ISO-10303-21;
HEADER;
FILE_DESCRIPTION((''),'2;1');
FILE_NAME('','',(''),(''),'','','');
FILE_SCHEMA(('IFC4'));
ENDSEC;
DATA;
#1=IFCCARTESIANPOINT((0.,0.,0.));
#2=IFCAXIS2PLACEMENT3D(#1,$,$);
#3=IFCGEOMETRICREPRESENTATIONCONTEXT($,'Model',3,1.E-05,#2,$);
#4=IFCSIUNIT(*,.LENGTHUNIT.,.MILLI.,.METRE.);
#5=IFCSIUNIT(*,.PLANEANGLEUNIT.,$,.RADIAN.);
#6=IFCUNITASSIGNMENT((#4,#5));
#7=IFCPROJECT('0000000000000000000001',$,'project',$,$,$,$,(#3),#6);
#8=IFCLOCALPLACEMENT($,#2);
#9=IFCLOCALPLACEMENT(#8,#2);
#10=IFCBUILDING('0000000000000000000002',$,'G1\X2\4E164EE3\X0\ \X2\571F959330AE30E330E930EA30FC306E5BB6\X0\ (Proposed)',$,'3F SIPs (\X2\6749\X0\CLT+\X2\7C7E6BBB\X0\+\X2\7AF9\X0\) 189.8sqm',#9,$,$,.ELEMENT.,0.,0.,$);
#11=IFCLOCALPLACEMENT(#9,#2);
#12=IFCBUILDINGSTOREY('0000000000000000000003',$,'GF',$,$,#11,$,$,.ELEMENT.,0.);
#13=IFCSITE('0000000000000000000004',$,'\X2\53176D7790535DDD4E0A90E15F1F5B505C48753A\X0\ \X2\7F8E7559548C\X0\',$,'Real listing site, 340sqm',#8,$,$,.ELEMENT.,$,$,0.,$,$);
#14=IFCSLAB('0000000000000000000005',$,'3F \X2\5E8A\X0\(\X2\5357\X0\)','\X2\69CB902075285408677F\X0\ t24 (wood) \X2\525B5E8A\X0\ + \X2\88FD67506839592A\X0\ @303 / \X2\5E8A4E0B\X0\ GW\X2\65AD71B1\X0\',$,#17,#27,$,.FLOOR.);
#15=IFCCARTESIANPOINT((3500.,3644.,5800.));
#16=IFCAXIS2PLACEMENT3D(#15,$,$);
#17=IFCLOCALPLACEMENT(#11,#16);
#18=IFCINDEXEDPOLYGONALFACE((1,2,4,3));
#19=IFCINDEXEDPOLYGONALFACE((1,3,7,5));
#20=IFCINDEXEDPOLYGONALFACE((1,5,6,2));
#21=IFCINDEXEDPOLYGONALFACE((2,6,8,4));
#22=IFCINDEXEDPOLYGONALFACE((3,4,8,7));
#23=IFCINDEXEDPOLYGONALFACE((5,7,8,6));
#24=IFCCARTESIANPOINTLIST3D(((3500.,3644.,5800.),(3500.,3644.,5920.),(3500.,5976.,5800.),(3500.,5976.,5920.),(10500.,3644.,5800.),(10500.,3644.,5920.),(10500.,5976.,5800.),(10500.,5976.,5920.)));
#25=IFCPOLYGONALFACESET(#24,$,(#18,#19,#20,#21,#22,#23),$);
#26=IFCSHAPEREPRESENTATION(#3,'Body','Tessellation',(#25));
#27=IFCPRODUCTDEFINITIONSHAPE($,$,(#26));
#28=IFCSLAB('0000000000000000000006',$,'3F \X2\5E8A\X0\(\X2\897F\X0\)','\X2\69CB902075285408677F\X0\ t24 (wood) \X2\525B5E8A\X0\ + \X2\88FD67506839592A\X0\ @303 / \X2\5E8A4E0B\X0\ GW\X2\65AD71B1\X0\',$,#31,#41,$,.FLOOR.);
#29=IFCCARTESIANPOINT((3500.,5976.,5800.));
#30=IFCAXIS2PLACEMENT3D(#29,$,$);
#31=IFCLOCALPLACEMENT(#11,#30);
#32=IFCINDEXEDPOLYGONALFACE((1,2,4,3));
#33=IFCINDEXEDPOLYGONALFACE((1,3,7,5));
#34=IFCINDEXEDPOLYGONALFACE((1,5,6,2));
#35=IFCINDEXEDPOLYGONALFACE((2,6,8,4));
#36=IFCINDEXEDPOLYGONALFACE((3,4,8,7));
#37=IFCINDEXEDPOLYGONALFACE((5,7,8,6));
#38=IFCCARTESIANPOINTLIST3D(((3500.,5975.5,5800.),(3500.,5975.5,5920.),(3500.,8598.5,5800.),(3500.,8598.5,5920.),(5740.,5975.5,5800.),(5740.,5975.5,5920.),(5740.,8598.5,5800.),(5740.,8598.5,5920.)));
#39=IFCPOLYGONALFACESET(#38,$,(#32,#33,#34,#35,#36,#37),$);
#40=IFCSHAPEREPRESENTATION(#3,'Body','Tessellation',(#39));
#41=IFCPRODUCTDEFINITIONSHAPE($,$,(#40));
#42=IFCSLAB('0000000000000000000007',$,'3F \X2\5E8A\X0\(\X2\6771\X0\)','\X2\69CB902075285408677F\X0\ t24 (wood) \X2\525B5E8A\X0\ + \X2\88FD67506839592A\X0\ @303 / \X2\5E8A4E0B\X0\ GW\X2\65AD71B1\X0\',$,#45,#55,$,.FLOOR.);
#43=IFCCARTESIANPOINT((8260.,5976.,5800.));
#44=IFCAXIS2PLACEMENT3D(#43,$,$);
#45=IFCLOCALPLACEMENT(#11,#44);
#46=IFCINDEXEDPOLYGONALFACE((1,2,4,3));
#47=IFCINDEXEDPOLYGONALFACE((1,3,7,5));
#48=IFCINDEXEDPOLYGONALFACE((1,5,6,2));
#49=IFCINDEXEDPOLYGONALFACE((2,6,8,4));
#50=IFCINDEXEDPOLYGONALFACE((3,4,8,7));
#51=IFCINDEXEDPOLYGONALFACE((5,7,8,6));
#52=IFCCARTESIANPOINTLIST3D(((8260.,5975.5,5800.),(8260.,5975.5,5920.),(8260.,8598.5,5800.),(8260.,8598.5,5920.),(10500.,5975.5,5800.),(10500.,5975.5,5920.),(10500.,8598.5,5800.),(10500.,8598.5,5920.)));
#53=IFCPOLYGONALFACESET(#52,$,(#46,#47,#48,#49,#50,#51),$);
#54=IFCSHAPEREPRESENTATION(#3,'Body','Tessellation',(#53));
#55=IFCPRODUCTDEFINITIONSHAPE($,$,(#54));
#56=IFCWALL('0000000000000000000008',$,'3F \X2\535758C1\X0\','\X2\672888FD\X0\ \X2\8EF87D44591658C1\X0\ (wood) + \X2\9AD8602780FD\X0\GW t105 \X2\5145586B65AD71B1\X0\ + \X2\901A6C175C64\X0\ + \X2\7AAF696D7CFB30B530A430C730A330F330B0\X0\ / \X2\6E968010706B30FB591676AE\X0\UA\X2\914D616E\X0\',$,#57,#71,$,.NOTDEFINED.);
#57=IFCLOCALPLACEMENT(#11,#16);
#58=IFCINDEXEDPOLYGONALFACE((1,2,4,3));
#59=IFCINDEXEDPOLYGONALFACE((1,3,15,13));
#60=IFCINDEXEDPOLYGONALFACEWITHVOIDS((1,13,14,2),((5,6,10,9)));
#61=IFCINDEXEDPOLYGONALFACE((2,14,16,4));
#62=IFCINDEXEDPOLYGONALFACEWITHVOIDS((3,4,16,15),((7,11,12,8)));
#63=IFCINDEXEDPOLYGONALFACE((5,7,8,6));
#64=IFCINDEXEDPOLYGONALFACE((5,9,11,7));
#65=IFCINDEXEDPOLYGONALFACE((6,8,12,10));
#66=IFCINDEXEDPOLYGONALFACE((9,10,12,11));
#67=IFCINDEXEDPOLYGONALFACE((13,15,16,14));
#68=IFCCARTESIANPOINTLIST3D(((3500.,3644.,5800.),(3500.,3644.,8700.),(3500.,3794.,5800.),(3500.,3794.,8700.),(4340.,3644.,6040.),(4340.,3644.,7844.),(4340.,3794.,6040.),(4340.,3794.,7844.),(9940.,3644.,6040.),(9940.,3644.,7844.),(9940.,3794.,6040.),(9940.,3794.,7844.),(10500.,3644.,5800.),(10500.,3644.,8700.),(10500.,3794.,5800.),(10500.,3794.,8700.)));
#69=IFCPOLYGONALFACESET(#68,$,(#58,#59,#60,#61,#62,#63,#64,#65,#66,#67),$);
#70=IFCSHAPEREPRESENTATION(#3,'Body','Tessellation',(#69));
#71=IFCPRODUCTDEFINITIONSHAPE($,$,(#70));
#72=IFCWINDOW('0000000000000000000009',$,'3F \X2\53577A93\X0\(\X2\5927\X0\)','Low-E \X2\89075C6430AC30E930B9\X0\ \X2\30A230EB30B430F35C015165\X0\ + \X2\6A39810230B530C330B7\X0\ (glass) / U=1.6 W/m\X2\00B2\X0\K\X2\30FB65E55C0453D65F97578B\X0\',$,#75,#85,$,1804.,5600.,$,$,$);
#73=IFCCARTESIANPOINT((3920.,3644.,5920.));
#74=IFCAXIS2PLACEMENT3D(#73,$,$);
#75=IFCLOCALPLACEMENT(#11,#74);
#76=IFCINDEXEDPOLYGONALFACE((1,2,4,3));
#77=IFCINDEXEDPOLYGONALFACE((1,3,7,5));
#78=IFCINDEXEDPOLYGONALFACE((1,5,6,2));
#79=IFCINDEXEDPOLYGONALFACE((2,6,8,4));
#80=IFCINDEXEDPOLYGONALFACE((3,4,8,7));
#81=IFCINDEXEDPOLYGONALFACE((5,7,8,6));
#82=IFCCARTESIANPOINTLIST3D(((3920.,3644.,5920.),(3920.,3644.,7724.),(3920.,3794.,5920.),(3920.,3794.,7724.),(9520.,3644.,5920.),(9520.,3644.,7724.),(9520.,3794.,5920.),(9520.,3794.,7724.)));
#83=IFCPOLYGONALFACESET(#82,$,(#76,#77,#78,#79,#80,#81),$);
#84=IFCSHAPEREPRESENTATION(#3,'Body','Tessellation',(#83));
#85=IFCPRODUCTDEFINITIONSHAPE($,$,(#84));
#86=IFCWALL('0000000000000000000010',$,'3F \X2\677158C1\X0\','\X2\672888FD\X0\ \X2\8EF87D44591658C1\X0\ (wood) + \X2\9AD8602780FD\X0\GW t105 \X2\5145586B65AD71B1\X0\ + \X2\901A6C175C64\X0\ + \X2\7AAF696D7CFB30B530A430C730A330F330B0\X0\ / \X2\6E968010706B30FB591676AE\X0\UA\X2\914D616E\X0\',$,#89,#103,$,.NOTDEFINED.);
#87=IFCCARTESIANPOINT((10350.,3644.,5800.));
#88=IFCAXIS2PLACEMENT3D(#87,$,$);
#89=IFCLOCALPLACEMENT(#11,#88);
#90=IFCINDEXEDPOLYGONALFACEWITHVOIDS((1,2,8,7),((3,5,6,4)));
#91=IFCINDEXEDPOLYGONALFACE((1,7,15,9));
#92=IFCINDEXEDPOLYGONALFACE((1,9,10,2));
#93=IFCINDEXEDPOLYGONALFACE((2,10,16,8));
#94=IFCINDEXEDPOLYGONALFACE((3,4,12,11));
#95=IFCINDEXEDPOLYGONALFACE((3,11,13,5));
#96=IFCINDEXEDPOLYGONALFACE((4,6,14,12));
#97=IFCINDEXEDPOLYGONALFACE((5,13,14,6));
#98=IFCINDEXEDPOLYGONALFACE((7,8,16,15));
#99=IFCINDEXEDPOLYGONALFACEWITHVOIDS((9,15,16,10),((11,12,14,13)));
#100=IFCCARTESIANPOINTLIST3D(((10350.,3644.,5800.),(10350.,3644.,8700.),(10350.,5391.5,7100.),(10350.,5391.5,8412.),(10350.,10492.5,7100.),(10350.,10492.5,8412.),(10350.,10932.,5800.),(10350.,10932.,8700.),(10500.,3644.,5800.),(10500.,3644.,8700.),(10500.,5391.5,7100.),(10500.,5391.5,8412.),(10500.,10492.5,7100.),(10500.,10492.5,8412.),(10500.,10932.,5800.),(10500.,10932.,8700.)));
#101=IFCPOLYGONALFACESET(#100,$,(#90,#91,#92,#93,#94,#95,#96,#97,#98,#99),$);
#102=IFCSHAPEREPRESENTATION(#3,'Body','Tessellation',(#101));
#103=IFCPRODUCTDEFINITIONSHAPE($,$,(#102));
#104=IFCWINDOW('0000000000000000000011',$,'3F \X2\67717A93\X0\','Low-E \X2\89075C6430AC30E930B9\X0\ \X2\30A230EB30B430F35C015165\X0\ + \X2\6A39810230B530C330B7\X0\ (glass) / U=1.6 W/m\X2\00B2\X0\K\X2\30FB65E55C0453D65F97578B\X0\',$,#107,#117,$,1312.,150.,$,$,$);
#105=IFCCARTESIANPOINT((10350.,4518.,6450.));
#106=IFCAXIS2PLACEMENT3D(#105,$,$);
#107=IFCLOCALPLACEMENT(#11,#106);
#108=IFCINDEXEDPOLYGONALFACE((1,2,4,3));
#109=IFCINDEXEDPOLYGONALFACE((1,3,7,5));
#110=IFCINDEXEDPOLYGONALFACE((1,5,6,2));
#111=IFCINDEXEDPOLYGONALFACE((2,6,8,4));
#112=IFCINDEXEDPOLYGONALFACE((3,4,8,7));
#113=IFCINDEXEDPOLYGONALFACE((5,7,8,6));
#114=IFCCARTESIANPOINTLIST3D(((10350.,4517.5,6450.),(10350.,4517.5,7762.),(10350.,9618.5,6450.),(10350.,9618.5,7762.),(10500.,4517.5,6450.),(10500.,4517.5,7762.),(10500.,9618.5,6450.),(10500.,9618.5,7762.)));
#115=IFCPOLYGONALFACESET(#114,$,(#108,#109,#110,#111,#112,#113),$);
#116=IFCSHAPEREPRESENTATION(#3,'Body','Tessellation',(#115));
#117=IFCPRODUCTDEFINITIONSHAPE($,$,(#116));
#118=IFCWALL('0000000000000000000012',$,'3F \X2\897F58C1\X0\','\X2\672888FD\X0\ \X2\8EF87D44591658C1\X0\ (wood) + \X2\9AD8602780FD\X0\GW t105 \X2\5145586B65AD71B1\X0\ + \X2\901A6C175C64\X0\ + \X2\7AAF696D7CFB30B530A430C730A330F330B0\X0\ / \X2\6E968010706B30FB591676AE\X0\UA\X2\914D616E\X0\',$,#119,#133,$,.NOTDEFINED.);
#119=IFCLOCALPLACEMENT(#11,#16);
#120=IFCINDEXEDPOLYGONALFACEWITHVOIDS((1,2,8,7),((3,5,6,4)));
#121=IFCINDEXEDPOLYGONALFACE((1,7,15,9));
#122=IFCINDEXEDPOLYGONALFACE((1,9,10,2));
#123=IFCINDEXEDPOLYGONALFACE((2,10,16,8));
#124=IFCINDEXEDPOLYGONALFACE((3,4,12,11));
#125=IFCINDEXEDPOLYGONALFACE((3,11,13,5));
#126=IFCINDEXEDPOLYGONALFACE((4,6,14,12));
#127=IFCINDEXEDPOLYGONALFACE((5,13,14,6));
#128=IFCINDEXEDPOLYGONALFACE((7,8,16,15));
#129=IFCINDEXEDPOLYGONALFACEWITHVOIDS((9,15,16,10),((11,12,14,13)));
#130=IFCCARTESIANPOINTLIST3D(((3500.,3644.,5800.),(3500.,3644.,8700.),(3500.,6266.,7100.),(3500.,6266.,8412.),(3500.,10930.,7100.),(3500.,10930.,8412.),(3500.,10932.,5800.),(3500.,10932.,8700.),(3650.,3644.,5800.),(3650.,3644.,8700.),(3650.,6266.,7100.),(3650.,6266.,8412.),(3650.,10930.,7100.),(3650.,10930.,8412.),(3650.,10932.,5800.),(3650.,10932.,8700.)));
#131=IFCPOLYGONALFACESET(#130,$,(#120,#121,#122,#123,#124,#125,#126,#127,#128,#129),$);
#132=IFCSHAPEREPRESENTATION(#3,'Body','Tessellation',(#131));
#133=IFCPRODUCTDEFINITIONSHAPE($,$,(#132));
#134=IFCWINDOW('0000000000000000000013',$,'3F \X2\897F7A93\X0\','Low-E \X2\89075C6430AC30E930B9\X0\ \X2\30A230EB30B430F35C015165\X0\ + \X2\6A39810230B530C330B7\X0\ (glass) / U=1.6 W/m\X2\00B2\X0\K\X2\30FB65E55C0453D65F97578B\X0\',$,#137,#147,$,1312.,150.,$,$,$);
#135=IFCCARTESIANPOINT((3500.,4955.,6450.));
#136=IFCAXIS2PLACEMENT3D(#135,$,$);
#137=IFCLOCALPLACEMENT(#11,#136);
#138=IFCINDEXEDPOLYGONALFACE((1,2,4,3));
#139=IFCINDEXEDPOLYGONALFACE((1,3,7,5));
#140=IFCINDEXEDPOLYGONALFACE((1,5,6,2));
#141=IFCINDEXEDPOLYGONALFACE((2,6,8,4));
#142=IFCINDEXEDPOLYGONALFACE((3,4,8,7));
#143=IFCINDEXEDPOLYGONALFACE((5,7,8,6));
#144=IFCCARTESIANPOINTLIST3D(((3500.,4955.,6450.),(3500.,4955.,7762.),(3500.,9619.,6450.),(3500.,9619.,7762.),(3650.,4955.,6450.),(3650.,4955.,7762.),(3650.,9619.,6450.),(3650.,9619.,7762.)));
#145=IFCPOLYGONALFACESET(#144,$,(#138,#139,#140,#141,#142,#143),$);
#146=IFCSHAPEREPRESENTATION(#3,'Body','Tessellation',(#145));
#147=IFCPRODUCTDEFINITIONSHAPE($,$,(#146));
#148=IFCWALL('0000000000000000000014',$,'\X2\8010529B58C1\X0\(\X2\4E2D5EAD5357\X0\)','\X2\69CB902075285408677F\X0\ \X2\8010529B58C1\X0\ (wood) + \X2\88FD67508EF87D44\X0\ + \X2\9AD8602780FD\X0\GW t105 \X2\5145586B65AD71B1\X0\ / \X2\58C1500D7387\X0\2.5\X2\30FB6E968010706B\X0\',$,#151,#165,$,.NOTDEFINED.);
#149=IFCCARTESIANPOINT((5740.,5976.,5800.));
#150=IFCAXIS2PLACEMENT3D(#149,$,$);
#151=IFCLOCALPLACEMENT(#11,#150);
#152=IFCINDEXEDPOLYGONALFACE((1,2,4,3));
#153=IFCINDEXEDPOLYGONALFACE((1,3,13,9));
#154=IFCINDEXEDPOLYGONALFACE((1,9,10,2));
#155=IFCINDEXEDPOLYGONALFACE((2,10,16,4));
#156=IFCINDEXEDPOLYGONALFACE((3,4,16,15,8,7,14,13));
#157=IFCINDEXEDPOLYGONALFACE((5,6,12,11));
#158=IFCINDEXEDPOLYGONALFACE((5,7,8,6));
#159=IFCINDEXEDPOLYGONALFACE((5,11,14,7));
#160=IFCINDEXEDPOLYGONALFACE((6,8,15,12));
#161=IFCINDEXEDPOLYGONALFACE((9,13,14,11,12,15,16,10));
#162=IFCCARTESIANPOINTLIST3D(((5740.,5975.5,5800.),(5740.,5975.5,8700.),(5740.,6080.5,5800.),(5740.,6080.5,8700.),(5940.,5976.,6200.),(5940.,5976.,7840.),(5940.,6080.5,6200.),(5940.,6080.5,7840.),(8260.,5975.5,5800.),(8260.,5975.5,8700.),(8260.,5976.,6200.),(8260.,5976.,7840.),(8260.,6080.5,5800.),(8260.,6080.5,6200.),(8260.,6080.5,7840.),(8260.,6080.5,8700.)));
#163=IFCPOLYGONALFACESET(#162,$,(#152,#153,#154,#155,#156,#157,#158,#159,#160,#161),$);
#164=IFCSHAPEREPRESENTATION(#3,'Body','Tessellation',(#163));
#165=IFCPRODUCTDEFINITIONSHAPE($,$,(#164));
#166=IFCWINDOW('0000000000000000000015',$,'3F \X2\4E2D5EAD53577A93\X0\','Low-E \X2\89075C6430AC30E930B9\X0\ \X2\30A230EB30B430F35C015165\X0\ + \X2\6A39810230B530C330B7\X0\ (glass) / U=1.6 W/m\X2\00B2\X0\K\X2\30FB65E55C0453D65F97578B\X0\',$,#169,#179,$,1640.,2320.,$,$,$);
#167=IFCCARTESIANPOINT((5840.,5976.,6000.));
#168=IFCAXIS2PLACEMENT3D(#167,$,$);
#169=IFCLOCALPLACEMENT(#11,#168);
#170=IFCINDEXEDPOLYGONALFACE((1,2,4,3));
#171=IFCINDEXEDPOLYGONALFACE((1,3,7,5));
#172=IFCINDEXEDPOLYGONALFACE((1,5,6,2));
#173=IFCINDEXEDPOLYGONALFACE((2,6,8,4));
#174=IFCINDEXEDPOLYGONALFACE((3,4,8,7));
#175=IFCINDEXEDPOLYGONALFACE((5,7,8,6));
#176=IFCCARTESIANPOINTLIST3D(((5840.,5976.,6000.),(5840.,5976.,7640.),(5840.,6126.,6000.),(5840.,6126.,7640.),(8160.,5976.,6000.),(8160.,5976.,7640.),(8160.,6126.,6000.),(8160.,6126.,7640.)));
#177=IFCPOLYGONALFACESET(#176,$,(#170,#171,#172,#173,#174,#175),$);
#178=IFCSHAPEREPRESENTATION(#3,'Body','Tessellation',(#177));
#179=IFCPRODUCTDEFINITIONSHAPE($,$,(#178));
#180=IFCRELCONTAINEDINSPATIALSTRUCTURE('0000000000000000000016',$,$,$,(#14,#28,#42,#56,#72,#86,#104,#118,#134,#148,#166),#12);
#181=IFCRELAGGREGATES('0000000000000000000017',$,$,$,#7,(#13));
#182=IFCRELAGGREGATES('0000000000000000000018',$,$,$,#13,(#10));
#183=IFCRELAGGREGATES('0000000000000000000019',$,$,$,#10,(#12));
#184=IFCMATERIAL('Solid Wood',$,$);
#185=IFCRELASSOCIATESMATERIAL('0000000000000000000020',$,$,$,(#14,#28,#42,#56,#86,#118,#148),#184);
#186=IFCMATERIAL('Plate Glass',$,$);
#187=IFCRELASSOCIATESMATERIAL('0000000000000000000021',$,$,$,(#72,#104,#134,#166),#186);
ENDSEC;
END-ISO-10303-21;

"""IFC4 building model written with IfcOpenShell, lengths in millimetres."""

from ifc_helpers import new_model, si_unit, frame, frame_2d, origin, place, context, project, spatial, rectangle, extrude, material, element, fill, save


model = new_model("IFC4")

# Units and contexts
model_context = context("Model", 3, precision=1e-05, world=origin())
ifc_project = project(units=[si_unit("LENGTHUNIT", "METRE", prefix="MILLI"), si_unit("PLANEANGLEUNIT", "RADIAN")], contexts=[model_context])

# Site, building, storey
site_placement = place(None, origin())
site = spatial("IfcSite", under=ifc_project, at=site_placement, Name="北海道川上郡弟子屈町 美留和", ObjectType="Real listing site, 340sqm", CompositionType="ELEMENT", RefElevation=0.0)
building_placement = place(site_placement, origin())
building = spatial("IfcBuilding", under=site, at=building_placement, Name="G1世代 土間ギャラリーの家 (Proposed)", ObjectType="3F SIPs (杉CLT+籾殻+竹) 189.8sqm", CompositionType="ELEMENT", ElevationOfRefHeight=0.0, ElevationOfTerrain=0.0)
storey_placement = place(building_placement, origin())
storey = spatial("IfcBuildingStorey", under=building, at=storey_placement, Name="GF", CompositionType="ELEMENT", Elevation=0.0)

# Slabs
ifc_material_1 = material(Name="Solid Wood")
slab_1_placement = place(storey_placement, frame((3500.0, 3644.0, 5800.0)))
element("IfcSlab", 1, at=slab_1_placement, inside=storey, material=ifc_material_1, Name="3F 床(南)", Description="構造用合板 t24 (wood) 剛床 + 製材根太 @303 / 床下 GW断熱", PredefinedType="FLOOR", context=model_context, shape_type="SweptSolid", body=[
    extrude(rectangle(XDim=7000.0, YDim=2332.0, at=frame_2d((3500.0, 1166.0))), frame((3500.0, 3644.0, 5800.0)), (0.0, 0.0, 1.0), 120.0),
])
slab_2_placement = place(storey_placement, frame((3500.0, 5976.0, 5800.0)))
element("IfcSlab", 2, at=slab_2_placement, inside=storey, material=ifc_material_1, Name="3F 床(西)", Description="構造用合板 t24 (wood) 剛床 + 製材根太 @303 / 床下 GW断熱", PredefinedType="FLOOR", context=model_context, shape_type="SweptSolid", body=[
    extrude(rectangle(XDim=2240.0, YDim=2623.0, at=frame_2d((1120.0, 1311.0))), frame((3500.0, 5976.0, 5800.0)), (0.0, 0.0, 1.0), 120.0),
])
slab_3_placement = place(storey_placement, frame((8260.0, 5976.0, 5800.0)))
element("IfcSlab", 3, at=slab_3_placement, inside=storey, material=ifc_material_1, Name="3F 床(東)", Description="構造用合板 t24 (wood) 剛床 + 製材根太 @303 / 床下 GW断熱", PredefinedType="FLOOR", context=model_context, shape_type="SweptSolid", body=[
    extrude(rectangle(XDim=2240.0, YDim=2623.0, at=frame_2d((1120.0, 1311.0))), frame((8260.0, 5976.0, 5800.0)), (0.0, 0.0, 1.0), 120.0),
])

# Walls, openings, windows
wall_1_placement = place(storey_placement, frame((3500.0, 3644.0, 5800.0)))
wall_1 = element("IfcWall", 4, at=wall_1_placement, inside=storey, material=ifc_material_1, Name="3F 南壁", Description="木製 軸組外壁 (wood) + 高性能GW t105 充填断熱 + 通気層 + 窯業系サイディング / 準耐火・外皮UA配慮", PredefinedType="NOTDEFINED", context=model_context, shape_type="SweptSolid", body=[
    extrude(rectangle(XDim=7000.0, YDim=150.0, at=frame_2d((3500.0, 75.0))), frame((3500.0, 3644.0, 5800.0)), (0.0, 0.0, 1.0), 2900.0),
])
opening_1_placement = place(storey_placement, frame((3920.0, 3644.0, 5920.0)))
opening_1 = element("IfcOpeningElement", 5, at=opening_1_placement, cuts=wall_1, PredefinedType="NOTDEFINED", context=model_context, shape_type="SweptSolid", body=[
    extrude(rectangle(XDim=5600.0, YDim=150.0, at=frame_2d((2800.0, 75.0))), frame((3920.0, 3644.0, 5920.0)), (0.0, 0.0, 1.0), 1804.0),
])
ifc_material_2 = material(Name="Plate Glass")
window_1_placement = place(storey_placement, frame((3920.0, 3644.0, 5920.0)))
window_1 = element("IfcWindow", 6, at=window_1_placement, inside=storey, material=ifc_material_2, Name="3F 南窓(大)", Description="Low-E 複層ガラス アルゴン封入 + 樹脂サッシ (glass) / U=1.6 W/m²K・日射取得型", OverallHeight=1804.0, OverallWidth=5600.0, context=model_context, shape_type="SweptSolid", body=[
    extrude(rectangle(XDim=5600.0, YDim=150.0, at=frame_2d((2800.0, 75.0))), frame((3920.0, 3644.0, 5920.0)), (0.0, 0.0, 1.0), 1804.0),
])
fill(opening_1, window_1)
wall_2_placement = place(storey_placement, frame((10350.0, 3644.0, 5800.0)))
wall_2 = element("IfcWall", 7, at=wall_2_placement, inside=storey, material=ifc_material_1, Name="3F 東壁", Description="木製 軸組外壁 (wood) + 高性能GW t105 充填断熱 + 通気層 + 窯業系サイディング / 準耐火・外皮UA配慮", PredefinedType="NOTDEFINED", context=model_context, shape_type="SweptSolid", body=[
    extrude(rectangle(XDim=150.0, YDim=7288.0, at=frame_2d((75.0, 3644.0))), frame((10350.0, 3644.0, 5800.0)), (0.0, 0.0, 1.0), 2900.0),
])
opening_2_placement = place(storey_placement, frame((10350.0, 4518.0, 6450.0)))
opening_2 = element("IfcOpeningElement", 8, at=opening_2_placement, cuts=wall_2, PredefinedType="NOTDEFINED", context=model_context, shape_type="SweptSolid", body=[
    extrude(rectangle(XDim=150.0, YDim=5101.0, at=frame_2d((75.0, 2550.0))), frame((10350.0, 4518.0, 6450.0)), (0.0, 0.0, 1.0), 1312.0),
])
window_2_placement = place(storey_placement, frame((10350.0, 4518.0, 6450.0)))
window_2 = element("IfcWindow", 9, at=window_2_placement, inside=storey, material=ifc_material_2, Name="3F 東窓", Description="Low-E 複層ガラス アルゴン封入 + 樹脂サッシ (glass) / U=1.6 W/m²K・日射取得型", OverallHeight=1312.0, OverallWidth=150.0, context=model_context, shape_type="SweptSolid", body=[
    extrude(rectangle(XDim=150.0, YDim=5101.0, at=frame_2d((75.0, 2550.0))), frame((10350.0, 4518.0, 6450.0)), (0.0, 0.0, 1.0), 1312.0),
])
fill(opening_2, window_2)
wall_3_placement = place(storey_placement, frame((3500.0, 3644.0, 5800.0)))
wall_3 = element("IfcWall", 10, at=wall_3_placement, inside=storey, material=ifc_material_1, Name="3F 西壁", Description="木製 軸組外壁 (wood) + 高性能GW t105 充填断熱 + 通気層 + 窯業系サイディング / 準耐火・外皮UA配慮", PredefinedType="NOTDEFINED", context=model_context, shape_type="SweptSolid", body=[
    extrude(rectangle(XDim=150.0, YDim=7288.0, at=frame_2d((75.0, 3644.0))), frame((3500.0, 3644.0, 5800.0)), (0.0, 0.0, 1.0), 2900.0),
])
opening_3_placement = place(storey_placement, frame((3500.0, 4955.0, 6450.0)))
opening_3 = element("IfcOpeningElement", 11, at=opening_3_placement, cuts=wall_3, PredefinedType="NOTDEFINED", context=model_context, shape_type="SweptSolid", body=[
    extrude(rectangle(XDim=150.0, YDim=4664.0, at=frame_2d((75.0, 2332.0))), frame((3500.0, 4955.0, 6450.0)), (0.0, 0.0, 1.0), 1312.0),
])
window_3_placement = place(storey_placement, frame((3500.0, 4955.0, 6450.0)))
window_3 = element("IfcWindow", 12, at=window_3_placement, inside=storey, material=ifc_material_2, Name="3F 西窓", Description="Low-E 複層ガラス アルゴン封入 + 樹脂サッシ (glass) / U=1.6 W/m²K・日射取得型", OverallHeight=1312.0, OverallWidth=150.0, context=model_context, shape_type="SweptSolid", body=[
    extrude(rectangle(XDim=150.0, YDim=4664.0, at=frame_2d((75.0, 2332.0))), frame((3500.0, 4955.0, 6450.0)), (0.0, 0.0, 1.0), 1312.0),
])
fill(opening_3, window_3)
wall_4_placement = place(storey_placement, frame((5740.0, 5976.0, 5800.0)))
wall_4 = element("IfcWall", 13, at=wall_4_placement, inside=storey, material=ifc_material_1, Name="耐力壁(中庭南)", Description="構造用合板 耐力壁 (wood) + 製材軸組 + 高性能GW t105 充填断熱 / 壁倍率2.5・準耐火", PredefinedType="NOTDEFINED", context=model_context, shape_type="SweptSolid", body=[
    extrude(rectangle(XDim=2520.0, YDim=105.0, at=frame_2d((1260.0, 52.0))), frame((5740.0, 5976.0, 5800.0)), (0.0, 0.0, 1.0), 2900.0),
])
opening_4_placement = place(storey_placement, frame((5840.0, 5976.0, 6000.0)))
opening_4 = element("IfcOpeningElement", 14, at=opening_4_placement, cuts=wall_4, PredefinedType="NOTDEFINED", context=model_context, shape_type="SweptSolid", body=[
    extrude(rectangle(XDim=2320.0, YDim=150.0, at=frame_2d((1160.0, 75.0))), frame((5840.0, 5976.0, 6000.0)), (0.0, 0.0, 1.0), 1640.0),
])
window_4_placement = place(storey_placement, frame((5840.0, 5976.0, 6000.0)))
window_4 = element("IfcWindow", 15, at=window_4_placement, inside=storey, material=ifc_material_2, Name="3F 中庭南窓", Description="Low-E 複層ガラス アルゴン封入 + 樹脂サッシ (glass) / U=1.6 W/m²K・日射取得型", OverallHeight=1640.0, OverallWidth=2320.0, context=model_context, shape_type="SweptSolid", body=[
    extrude(rectangle(XDim=2320.0, YDim=150.0, at=frame_2d((1160.0, 75.0))), frame((5840.0, 5976.0, 6000.0)), (0.0, 0.0, 1.0), 1640.0),
])
fill(opening_4, window_4)

save(model, "model.ifc")
